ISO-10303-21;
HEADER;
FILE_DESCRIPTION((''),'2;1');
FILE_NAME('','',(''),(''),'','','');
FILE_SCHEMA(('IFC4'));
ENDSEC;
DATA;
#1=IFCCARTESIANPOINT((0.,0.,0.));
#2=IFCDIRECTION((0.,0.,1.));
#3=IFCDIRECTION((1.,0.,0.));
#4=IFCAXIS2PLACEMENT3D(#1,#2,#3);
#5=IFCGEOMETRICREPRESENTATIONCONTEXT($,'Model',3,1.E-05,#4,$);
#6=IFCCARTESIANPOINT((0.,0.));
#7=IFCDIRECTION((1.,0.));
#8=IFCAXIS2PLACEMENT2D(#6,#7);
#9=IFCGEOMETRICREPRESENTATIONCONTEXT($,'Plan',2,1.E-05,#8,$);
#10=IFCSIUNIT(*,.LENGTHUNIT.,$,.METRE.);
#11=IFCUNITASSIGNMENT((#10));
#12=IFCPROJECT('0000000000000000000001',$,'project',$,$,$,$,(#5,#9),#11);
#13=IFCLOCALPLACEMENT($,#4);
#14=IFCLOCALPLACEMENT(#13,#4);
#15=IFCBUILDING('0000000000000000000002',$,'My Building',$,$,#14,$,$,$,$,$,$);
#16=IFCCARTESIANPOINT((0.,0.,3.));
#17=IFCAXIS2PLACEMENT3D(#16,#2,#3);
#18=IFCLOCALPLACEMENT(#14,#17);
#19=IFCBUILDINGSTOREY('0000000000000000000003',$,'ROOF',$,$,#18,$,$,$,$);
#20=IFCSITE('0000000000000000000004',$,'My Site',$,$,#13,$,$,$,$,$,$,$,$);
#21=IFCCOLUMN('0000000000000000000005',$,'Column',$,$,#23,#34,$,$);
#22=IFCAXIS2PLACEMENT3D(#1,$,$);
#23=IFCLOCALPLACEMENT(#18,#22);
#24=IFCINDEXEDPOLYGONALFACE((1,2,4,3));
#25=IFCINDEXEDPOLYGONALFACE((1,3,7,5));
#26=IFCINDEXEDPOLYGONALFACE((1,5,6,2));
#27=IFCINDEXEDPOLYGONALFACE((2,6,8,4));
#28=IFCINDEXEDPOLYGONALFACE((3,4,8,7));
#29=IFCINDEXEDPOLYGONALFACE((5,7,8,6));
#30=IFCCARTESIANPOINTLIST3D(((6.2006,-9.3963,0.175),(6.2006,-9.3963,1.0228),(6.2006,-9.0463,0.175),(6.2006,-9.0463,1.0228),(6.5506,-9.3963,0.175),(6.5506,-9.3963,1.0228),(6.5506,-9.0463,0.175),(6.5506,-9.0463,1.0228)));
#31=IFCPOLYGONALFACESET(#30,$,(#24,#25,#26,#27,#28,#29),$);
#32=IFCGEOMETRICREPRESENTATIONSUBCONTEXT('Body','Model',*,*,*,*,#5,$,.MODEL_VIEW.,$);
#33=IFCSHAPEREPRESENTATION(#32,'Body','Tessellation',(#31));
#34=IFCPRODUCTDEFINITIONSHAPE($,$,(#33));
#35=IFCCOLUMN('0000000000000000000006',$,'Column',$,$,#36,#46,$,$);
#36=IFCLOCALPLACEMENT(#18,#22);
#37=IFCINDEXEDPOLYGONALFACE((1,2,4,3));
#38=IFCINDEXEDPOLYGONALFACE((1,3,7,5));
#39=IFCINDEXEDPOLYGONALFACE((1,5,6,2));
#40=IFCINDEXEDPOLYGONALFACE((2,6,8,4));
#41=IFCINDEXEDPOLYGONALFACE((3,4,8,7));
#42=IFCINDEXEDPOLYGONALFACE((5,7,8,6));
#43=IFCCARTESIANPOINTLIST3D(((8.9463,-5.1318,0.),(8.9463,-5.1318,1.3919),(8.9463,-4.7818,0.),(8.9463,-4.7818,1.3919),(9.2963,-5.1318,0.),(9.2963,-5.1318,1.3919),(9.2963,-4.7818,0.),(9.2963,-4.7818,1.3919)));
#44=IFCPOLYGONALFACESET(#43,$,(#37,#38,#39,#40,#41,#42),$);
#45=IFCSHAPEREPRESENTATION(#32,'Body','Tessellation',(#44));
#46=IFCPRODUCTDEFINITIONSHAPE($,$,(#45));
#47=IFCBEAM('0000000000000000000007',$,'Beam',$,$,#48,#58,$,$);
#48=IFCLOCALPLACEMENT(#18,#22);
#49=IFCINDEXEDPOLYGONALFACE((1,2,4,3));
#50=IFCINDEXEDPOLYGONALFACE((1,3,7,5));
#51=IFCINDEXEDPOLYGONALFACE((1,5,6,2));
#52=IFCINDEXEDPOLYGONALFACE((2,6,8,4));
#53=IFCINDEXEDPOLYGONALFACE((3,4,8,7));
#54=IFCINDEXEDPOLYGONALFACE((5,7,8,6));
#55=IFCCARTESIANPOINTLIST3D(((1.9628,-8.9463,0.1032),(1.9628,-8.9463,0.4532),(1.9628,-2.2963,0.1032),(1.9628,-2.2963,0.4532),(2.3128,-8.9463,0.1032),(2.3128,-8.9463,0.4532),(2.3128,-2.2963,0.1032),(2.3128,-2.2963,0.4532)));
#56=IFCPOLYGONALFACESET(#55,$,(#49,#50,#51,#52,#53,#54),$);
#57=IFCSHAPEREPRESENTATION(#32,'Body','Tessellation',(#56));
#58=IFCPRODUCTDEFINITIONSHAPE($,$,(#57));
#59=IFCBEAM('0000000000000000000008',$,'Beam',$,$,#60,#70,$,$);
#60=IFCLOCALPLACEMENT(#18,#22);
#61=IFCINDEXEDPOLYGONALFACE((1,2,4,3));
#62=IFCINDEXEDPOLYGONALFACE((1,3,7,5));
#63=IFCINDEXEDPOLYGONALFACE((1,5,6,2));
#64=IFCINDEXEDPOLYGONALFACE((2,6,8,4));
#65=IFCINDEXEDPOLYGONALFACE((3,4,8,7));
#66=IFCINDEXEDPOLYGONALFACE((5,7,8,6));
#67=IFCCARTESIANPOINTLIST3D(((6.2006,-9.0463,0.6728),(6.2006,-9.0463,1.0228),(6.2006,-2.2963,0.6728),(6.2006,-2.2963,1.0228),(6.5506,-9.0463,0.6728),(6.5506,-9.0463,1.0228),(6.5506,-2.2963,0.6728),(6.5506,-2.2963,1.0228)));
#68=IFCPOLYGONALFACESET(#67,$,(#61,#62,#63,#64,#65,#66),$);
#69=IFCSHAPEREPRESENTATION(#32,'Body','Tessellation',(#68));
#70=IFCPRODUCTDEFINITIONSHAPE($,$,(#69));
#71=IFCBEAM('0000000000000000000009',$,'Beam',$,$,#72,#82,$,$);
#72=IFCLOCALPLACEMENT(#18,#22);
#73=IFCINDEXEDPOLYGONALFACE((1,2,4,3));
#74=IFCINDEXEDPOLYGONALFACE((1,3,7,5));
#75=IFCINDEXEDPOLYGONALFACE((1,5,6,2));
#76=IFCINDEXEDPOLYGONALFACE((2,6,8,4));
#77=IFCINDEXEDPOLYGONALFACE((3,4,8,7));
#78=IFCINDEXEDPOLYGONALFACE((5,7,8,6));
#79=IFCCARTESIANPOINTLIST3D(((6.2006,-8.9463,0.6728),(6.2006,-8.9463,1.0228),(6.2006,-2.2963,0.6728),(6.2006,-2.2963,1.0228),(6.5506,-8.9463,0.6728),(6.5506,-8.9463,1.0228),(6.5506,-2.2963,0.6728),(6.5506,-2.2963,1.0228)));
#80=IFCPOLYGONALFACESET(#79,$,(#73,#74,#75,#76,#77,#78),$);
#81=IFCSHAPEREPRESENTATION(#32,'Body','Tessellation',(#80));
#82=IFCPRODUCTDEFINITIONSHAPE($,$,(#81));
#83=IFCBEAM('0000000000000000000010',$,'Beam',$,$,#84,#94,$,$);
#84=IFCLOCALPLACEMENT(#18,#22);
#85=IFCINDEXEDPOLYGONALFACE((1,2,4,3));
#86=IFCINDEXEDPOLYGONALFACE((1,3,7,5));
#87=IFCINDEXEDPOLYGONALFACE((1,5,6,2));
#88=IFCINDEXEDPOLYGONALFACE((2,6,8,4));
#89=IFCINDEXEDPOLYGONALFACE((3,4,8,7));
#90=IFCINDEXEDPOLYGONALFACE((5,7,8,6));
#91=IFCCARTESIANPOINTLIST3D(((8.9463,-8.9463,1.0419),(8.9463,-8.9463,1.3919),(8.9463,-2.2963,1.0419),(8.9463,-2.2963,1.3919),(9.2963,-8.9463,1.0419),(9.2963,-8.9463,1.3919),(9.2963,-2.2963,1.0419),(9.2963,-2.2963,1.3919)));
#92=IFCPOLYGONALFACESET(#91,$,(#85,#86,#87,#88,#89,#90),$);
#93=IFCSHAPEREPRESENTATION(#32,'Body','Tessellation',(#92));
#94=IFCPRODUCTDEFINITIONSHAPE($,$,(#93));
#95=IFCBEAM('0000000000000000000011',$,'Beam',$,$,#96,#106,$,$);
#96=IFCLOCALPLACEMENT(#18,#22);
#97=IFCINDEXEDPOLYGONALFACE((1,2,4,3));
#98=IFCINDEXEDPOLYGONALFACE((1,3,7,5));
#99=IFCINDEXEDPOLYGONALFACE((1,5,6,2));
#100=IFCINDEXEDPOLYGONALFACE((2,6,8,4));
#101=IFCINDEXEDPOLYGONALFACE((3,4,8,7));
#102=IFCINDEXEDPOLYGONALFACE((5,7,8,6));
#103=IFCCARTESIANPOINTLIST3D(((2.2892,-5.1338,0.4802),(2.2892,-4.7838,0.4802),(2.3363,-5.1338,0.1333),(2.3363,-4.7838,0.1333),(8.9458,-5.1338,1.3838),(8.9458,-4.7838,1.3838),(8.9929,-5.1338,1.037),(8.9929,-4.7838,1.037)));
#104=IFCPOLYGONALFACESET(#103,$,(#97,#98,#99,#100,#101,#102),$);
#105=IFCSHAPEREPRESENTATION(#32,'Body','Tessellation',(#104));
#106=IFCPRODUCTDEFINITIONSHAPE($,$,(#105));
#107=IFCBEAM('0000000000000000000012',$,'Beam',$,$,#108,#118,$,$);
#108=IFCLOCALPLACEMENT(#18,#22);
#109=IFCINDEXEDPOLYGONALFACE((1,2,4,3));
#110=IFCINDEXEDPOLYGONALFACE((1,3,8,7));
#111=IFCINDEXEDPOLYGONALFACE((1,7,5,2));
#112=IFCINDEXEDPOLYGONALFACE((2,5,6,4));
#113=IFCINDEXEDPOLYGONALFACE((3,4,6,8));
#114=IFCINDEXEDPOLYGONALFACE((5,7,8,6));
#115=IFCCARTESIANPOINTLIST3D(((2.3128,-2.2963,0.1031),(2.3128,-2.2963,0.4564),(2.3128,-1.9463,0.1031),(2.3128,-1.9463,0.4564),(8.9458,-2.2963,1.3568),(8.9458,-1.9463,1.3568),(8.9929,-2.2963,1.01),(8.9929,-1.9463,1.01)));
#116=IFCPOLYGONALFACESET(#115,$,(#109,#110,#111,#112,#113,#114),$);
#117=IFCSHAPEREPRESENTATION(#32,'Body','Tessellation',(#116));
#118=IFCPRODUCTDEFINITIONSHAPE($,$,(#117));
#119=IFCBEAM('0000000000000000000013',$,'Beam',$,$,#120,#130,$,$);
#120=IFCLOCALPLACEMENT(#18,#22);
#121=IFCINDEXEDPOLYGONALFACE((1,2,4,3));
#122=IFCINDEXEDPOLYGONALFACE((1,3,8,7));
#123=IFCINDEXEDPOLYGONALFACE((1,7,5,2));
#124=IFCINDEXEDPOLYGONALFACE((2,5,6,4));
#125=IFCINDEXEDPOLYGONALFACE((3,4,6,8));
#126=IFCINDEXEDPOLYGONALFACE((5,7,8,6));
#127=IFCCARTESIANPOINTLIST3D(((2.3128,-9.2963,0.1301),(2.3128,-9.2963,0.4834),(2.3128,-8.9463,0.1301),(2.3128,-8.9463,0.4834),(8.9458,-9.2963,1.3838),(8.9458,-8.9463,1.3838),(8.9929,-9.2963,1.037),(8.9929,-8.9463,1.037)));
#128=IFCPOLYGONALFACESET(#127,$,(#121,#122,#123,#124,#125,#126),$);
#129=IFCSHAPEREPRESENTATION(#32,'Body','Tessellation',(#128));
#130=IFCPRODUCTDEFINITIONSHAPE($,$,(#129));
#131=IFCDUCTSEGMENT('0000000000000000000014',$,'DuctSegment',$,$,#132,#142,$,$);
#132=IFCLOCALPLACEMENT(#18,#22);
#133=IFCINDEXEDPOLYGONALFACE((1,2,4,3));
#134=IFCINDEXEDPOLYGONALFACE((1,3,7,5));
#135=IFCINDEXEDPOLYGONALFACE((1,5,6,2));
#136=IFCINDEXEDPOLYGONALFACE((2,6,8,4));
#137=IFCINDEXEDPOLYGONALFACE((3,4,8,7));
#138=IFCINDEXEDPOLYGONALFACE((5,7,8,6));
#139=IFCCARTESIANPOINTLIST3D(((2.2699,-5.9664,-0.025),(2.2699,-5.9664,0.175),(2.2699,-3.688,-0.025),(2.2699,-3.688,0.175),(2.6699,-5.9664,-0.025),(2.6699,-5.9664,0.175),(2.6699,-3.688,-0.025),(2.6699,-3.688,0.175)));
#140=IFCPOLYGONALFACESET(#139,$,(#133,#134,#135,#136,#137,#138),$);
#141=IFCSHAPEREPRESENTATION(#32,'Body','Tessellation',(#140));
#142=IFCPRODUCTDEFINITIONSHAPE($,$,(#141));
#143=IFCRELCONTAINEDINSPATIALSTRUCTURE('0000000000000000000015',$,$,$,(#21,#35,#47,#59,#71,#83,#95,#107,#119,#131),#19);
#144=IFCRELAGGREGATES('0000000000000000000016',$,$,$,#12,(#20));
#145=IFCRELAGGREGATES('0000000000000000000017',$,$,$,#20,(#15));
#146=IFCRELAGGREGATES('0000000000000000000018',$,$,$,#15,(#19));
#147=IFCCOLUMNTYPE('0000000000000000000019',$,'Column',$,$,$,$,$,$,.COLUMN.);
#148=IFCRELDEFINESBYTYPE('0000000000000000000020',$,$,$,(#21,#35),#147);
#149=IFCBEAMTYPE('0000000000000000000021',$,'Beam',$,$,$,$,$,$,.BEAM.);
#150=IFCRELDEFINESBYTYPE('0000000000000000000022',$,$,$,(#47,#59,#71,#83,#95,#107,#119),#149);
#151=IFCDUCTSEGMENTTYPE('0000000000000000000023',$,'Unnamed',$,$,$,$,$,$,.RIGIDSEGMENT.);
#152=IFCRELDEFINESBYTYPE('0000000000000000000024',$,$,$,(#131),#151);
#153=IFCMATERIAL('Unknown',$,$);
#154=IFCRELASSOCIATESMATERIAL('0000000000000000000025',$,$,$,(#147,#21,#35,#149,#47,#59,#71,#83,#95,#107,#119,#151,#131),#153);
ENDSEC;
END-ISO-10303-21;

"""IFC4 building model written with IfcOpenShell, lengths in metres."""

from ifc_helpers import new_model, si_unit, frame, origin_with_axes, origin_2d_with_axis, place, context, subcontext, project, spatial, rectangle, extrude, clip, halfspace, material, material_profile, profile_set, profile_usage, type_object, element, save


model = new_model("IFC4")

# Units and contexts
model_context = context("Model", 3, precision=1e-05, world=origin_with_axes())
plan_context = context("Plan", 2, precision=1e-05, world=origin_2d_with_axis())
body_context = subcontext(model_context, "Body", "Model", "MODEL_VIEW")
ifc_project = project(units=[si_unit("LENGTHUNIT", "METRE")], contexts=[model_context, plan_context])

# Site, building, storey
site_placement = place(None, origin_with_axes())
site = spatial("IfcSite", under=ifc_project, at=site_placement, Name="My Site")
building_placement = place(site_placement, origin_with_axes())
building = spatial("IfcBuilding", under=site, at=building_placement, Name="My Building")
storey_placement = place(building_placement, frame((0.0, 0.0, 3.0), z_axis=(0.0, 0.0, 1.0), x_axis=(1.0, 0.0, 0.0)))
storey = spatial("IfcBuildingStorey", under=building, at=storey_placement, Name="ROOF")

# Columns
ifc_material = material(Name="Unknown")
ifc_material_profile_1 = material_profile(ifc_material, rectangle(XDim=0.35, YDim=0.35))
ifc_profile_set_1 = profile_set([ifc_material_profile_1])
ifc_profile_usage_1 = profile_usage(ifc_profile_set_1, cardinal=5)
column_type = type_object("IfcColumnType", Name="Column", PredefinedType="COLUMN", material=ifc_profile_set_1)
column_1_placement = place(storey_placement, frame((6.3756, -9.2213, 0.175), z_axis=(0.0, 0.0, 1.0), x_axis=(1.0, 0.0, 0.0)))
element("IfcColumn", 1, at=column_1_placement, inside=storey, type_object=column_type, material=ifc_profile_usage_1, Name="Column", context=body_context, shape_type="SweptSolid", body=[
    extrude(rectangle(XDim=0.35, YDim=0.35), origin_with_axes(), (0.0, 0.0, 1.0), 0.8478),
])
ifc_profile_usage_2 = profile_usage(ifc_profile_set_1, cardinal=5)
column_2_placement = place(storey_placement, frame((9.1213, -4.9568, 0.0), z_axis=(0.0, 0.0, 1.0), x_axis=(1.0, 0.0, 0.0)))
element("IfcColumn", 2, at=column_2_placement, inside=storey, type_object=column_type, material=ifc_profile_usage_2, Name="Column", context=body_context, shape_type="SweptSolid", body=[
    extrude(rectangle(XDim=0.35, YDim=0.35), origin_with_axes(), (0.0, 0.0, 1.0), 1.3919),
])

# Beams
ifc_material_profile_2 = material_profile(ifc_material, rectangle(XDim=0.35, YDim=0.35))
ifc_profile_set_2 = profile_set([ifc_material_profile_2])
ifc_profile_usage_3 = profile_usage(ifc_profile_set_2, cardinal=5)
beam_type = type_object("IfcBeamType", Name="Beam", PredefinedType="BEAM", material=ifc_profile_set_2)
beam_1_placement = place(storey_placement, frame((2.1378, -2.2963, 0.2782), z_axis=(0.0, -1.0, 0.0), x_axis=(1.0, 0.0, 0.0)))
element("IfcBeam", 3, at=beam_1_placement, inside=storey, type_object=beam_type, material=ifc_profile_usage_3, Name="Beam", context=body_context, shape_type="SweptSolid", body=[
    extrude(rectangle(XDim=0.35, YDim=0.35), origin_with_axes(), (0.0, 0.0, 1.0), 6.65),
])
ifc_profile_usage_4 = profile_usage(ifc_profile_set_2, cardinal=5)
beam_2_placement = place(storey_placement, frame((6.3756, -2.2963, 0.8478), z_axis=(0.0, -1.0, 0.0), x_axis=(1.0, 0.0, 0.0)))
element("IfcBeam", 4, at=beam_2_placement, inside=storey, type_object=beam_type, material=ifc_profile_usage_4, Name="Beam", context=body_context, shape_type="SweptSolid", body=[
    extrude(rectangle(XDim=0.35, YDim=0.35), origin_with_axes(), (0.0, 0.0, 1.0), 6.75),
])
ifc_profile_usage_5 = profile_usage(ifc_profile_set_2, cardinal=5)
beam_3_placement = place(storey_placement, frame((6.3756, -2.2963, 0.8478), z_axis=(0.0, -1.0, 0.0), x_axis=(1.0, 0.0, 0.0)))
element("IfcBeam", 5, at=beam_3_placement, inside=storey, type_object=beam_type, material=ifc_profile_usage_5, Name="Beam", context=body_context, shape_type="SweptSolid", body=[
    extrude(rectangle(XDim=0.35, YDim=0.35), origin_with_axes(), (0.0, 0.0, 1.0), 6.65),
])
ifc_profile_usage_6 = profile_usage(ifc_profile_set_2, cardinal=5)
beam_4_placement = place(storey_placement, frame((9.1213, -2.2963, 1.2169), z_axis=(0.0, -1.0, 0.0), x_axis=(1.0, 0.0, 0.0)))
element("IfcBeam", 6, at=beam_4_placement, inside=storey, type_object=beam_type, material=ifc_profile_usage_6, Name="Beam", context=body_context, shape_type="SweptSolid", body=[
    extrude(rectangle(XDim=0.35, YDim=0.35), origin_with_axes(), (0.0, 0.0, 1.0), 6.65),
])
ifc_profile_usage_7 = profile_usage(ifc_profile_set_2, cardinal=5)
beam_5_placement = place(storey_placement, frame((8.9693, -4.9588, 1.2104), z_axis=(-0.99091, 0.0, -0.134523), x_axis=(0.0, -1.0, 0.0)))
element("IfcBeam", 7, at=beam_5_placement, inside=storey, type_object=beam_type, material=ifc_profile_usage_7, Name="Beam", context=body_context, shape_type="SweptSolid", body=[
    extrude(rectangle(XDim=0.35, YDim=0.35), origin_with_axes(), (0.0, 0.0, 1.0), 6.7177),
])
ifc_profile_usage_8 = profile_usage(ifc_profile_set_2, cardinal=5)
beam_6_placement = place(storey_placement, frame((8.9693, -2.1213, 1.1834), z_axis=(-0.99091, 0.0, -0.134523), x_axis=(0.0, -1.0, 0.0)))
element("IfcBeam", 8, at=beam_6_placement, inside=storey, type_object=beam_type, material=ifc_profile_usage_8, Name="Beam", context=body_context, shape_type="Clipping", body=[
    clip(extrude(rectangle(XDim=0.35, YDim=0.35), origin_with_axes(), (0.0, 0.0, 1.0), 7.0677), halfspace(frame((0.0, -3.349, 7.1723), z_axis=(0.0, 0.134523, 0.99091), x_axis=(1.0, -0.000001, 0.0)), False)),
])
ifc_profile_usage_9 = profile_usage(ifc_profile_set_2, cardinal=5)
beam_7_placement = place(storey_placement, frame((8.9693, -9.1213, 1.2104), z_axis=(-0.99091, 0.0, -0.134523), x_axis=(0.0, -1.0, 0.0)))
element("IfcBeam", 9, at=beam_7_placement, inside=storey, type_object=beam_type, material=ifc_profile_usage_9, Name="Beam", context=body_context, shape_type="Clipping", body=[
    clip(extrude(rectangle(XDim=0.35, YDim=0.35), origin_with_axes(), (0.0, 0.0, 1.0), 7.0677), halfspace(frame((0.0, -3.3758, 7.1759), z_axis=(0.0, 0.134523, 0.99091), x_axis=(1.0, -0.000001, 0.0)), False)),
])

# Duct segment
ifc_material_profile_3 = material_profile(ifc_material, rectangle(XDim=0.4, YDim=0.2))
ifc_profile_set_3 = profile_set([ifc_material_profile_3])
ifc_profile_usage_10 = profile_usage(ifc_profile_set_3, cardinal=5)
duct_segment_type = type_object("IfcDuctSegmentType", Name="Unnamed", PredefinedType="RIGIDSEGMENT", material=ifc_profile_set_3)
duct_segment_placement = place(storey_placement, frame((2.4699, -3.688, 0.075), z_axis=(0.0, -1.0, 0.0), x_axis=(1.0, 0.0, 0.0)))
element("IfcDuctSegment", 10, at=duct_segment_placement, inside=storey, type_object=duct_segment_type, material=ifc_profile_usage_10, Name="DuctSegment", context=body_context, shape_type="SweptSolid", body=[
    extrude(rectangle(XDim=0.4, YDim=0.2), origin_with_axes(), (0.0, 0.0, 1.0), 2.2784),
])

save(model, "model.ifc")
